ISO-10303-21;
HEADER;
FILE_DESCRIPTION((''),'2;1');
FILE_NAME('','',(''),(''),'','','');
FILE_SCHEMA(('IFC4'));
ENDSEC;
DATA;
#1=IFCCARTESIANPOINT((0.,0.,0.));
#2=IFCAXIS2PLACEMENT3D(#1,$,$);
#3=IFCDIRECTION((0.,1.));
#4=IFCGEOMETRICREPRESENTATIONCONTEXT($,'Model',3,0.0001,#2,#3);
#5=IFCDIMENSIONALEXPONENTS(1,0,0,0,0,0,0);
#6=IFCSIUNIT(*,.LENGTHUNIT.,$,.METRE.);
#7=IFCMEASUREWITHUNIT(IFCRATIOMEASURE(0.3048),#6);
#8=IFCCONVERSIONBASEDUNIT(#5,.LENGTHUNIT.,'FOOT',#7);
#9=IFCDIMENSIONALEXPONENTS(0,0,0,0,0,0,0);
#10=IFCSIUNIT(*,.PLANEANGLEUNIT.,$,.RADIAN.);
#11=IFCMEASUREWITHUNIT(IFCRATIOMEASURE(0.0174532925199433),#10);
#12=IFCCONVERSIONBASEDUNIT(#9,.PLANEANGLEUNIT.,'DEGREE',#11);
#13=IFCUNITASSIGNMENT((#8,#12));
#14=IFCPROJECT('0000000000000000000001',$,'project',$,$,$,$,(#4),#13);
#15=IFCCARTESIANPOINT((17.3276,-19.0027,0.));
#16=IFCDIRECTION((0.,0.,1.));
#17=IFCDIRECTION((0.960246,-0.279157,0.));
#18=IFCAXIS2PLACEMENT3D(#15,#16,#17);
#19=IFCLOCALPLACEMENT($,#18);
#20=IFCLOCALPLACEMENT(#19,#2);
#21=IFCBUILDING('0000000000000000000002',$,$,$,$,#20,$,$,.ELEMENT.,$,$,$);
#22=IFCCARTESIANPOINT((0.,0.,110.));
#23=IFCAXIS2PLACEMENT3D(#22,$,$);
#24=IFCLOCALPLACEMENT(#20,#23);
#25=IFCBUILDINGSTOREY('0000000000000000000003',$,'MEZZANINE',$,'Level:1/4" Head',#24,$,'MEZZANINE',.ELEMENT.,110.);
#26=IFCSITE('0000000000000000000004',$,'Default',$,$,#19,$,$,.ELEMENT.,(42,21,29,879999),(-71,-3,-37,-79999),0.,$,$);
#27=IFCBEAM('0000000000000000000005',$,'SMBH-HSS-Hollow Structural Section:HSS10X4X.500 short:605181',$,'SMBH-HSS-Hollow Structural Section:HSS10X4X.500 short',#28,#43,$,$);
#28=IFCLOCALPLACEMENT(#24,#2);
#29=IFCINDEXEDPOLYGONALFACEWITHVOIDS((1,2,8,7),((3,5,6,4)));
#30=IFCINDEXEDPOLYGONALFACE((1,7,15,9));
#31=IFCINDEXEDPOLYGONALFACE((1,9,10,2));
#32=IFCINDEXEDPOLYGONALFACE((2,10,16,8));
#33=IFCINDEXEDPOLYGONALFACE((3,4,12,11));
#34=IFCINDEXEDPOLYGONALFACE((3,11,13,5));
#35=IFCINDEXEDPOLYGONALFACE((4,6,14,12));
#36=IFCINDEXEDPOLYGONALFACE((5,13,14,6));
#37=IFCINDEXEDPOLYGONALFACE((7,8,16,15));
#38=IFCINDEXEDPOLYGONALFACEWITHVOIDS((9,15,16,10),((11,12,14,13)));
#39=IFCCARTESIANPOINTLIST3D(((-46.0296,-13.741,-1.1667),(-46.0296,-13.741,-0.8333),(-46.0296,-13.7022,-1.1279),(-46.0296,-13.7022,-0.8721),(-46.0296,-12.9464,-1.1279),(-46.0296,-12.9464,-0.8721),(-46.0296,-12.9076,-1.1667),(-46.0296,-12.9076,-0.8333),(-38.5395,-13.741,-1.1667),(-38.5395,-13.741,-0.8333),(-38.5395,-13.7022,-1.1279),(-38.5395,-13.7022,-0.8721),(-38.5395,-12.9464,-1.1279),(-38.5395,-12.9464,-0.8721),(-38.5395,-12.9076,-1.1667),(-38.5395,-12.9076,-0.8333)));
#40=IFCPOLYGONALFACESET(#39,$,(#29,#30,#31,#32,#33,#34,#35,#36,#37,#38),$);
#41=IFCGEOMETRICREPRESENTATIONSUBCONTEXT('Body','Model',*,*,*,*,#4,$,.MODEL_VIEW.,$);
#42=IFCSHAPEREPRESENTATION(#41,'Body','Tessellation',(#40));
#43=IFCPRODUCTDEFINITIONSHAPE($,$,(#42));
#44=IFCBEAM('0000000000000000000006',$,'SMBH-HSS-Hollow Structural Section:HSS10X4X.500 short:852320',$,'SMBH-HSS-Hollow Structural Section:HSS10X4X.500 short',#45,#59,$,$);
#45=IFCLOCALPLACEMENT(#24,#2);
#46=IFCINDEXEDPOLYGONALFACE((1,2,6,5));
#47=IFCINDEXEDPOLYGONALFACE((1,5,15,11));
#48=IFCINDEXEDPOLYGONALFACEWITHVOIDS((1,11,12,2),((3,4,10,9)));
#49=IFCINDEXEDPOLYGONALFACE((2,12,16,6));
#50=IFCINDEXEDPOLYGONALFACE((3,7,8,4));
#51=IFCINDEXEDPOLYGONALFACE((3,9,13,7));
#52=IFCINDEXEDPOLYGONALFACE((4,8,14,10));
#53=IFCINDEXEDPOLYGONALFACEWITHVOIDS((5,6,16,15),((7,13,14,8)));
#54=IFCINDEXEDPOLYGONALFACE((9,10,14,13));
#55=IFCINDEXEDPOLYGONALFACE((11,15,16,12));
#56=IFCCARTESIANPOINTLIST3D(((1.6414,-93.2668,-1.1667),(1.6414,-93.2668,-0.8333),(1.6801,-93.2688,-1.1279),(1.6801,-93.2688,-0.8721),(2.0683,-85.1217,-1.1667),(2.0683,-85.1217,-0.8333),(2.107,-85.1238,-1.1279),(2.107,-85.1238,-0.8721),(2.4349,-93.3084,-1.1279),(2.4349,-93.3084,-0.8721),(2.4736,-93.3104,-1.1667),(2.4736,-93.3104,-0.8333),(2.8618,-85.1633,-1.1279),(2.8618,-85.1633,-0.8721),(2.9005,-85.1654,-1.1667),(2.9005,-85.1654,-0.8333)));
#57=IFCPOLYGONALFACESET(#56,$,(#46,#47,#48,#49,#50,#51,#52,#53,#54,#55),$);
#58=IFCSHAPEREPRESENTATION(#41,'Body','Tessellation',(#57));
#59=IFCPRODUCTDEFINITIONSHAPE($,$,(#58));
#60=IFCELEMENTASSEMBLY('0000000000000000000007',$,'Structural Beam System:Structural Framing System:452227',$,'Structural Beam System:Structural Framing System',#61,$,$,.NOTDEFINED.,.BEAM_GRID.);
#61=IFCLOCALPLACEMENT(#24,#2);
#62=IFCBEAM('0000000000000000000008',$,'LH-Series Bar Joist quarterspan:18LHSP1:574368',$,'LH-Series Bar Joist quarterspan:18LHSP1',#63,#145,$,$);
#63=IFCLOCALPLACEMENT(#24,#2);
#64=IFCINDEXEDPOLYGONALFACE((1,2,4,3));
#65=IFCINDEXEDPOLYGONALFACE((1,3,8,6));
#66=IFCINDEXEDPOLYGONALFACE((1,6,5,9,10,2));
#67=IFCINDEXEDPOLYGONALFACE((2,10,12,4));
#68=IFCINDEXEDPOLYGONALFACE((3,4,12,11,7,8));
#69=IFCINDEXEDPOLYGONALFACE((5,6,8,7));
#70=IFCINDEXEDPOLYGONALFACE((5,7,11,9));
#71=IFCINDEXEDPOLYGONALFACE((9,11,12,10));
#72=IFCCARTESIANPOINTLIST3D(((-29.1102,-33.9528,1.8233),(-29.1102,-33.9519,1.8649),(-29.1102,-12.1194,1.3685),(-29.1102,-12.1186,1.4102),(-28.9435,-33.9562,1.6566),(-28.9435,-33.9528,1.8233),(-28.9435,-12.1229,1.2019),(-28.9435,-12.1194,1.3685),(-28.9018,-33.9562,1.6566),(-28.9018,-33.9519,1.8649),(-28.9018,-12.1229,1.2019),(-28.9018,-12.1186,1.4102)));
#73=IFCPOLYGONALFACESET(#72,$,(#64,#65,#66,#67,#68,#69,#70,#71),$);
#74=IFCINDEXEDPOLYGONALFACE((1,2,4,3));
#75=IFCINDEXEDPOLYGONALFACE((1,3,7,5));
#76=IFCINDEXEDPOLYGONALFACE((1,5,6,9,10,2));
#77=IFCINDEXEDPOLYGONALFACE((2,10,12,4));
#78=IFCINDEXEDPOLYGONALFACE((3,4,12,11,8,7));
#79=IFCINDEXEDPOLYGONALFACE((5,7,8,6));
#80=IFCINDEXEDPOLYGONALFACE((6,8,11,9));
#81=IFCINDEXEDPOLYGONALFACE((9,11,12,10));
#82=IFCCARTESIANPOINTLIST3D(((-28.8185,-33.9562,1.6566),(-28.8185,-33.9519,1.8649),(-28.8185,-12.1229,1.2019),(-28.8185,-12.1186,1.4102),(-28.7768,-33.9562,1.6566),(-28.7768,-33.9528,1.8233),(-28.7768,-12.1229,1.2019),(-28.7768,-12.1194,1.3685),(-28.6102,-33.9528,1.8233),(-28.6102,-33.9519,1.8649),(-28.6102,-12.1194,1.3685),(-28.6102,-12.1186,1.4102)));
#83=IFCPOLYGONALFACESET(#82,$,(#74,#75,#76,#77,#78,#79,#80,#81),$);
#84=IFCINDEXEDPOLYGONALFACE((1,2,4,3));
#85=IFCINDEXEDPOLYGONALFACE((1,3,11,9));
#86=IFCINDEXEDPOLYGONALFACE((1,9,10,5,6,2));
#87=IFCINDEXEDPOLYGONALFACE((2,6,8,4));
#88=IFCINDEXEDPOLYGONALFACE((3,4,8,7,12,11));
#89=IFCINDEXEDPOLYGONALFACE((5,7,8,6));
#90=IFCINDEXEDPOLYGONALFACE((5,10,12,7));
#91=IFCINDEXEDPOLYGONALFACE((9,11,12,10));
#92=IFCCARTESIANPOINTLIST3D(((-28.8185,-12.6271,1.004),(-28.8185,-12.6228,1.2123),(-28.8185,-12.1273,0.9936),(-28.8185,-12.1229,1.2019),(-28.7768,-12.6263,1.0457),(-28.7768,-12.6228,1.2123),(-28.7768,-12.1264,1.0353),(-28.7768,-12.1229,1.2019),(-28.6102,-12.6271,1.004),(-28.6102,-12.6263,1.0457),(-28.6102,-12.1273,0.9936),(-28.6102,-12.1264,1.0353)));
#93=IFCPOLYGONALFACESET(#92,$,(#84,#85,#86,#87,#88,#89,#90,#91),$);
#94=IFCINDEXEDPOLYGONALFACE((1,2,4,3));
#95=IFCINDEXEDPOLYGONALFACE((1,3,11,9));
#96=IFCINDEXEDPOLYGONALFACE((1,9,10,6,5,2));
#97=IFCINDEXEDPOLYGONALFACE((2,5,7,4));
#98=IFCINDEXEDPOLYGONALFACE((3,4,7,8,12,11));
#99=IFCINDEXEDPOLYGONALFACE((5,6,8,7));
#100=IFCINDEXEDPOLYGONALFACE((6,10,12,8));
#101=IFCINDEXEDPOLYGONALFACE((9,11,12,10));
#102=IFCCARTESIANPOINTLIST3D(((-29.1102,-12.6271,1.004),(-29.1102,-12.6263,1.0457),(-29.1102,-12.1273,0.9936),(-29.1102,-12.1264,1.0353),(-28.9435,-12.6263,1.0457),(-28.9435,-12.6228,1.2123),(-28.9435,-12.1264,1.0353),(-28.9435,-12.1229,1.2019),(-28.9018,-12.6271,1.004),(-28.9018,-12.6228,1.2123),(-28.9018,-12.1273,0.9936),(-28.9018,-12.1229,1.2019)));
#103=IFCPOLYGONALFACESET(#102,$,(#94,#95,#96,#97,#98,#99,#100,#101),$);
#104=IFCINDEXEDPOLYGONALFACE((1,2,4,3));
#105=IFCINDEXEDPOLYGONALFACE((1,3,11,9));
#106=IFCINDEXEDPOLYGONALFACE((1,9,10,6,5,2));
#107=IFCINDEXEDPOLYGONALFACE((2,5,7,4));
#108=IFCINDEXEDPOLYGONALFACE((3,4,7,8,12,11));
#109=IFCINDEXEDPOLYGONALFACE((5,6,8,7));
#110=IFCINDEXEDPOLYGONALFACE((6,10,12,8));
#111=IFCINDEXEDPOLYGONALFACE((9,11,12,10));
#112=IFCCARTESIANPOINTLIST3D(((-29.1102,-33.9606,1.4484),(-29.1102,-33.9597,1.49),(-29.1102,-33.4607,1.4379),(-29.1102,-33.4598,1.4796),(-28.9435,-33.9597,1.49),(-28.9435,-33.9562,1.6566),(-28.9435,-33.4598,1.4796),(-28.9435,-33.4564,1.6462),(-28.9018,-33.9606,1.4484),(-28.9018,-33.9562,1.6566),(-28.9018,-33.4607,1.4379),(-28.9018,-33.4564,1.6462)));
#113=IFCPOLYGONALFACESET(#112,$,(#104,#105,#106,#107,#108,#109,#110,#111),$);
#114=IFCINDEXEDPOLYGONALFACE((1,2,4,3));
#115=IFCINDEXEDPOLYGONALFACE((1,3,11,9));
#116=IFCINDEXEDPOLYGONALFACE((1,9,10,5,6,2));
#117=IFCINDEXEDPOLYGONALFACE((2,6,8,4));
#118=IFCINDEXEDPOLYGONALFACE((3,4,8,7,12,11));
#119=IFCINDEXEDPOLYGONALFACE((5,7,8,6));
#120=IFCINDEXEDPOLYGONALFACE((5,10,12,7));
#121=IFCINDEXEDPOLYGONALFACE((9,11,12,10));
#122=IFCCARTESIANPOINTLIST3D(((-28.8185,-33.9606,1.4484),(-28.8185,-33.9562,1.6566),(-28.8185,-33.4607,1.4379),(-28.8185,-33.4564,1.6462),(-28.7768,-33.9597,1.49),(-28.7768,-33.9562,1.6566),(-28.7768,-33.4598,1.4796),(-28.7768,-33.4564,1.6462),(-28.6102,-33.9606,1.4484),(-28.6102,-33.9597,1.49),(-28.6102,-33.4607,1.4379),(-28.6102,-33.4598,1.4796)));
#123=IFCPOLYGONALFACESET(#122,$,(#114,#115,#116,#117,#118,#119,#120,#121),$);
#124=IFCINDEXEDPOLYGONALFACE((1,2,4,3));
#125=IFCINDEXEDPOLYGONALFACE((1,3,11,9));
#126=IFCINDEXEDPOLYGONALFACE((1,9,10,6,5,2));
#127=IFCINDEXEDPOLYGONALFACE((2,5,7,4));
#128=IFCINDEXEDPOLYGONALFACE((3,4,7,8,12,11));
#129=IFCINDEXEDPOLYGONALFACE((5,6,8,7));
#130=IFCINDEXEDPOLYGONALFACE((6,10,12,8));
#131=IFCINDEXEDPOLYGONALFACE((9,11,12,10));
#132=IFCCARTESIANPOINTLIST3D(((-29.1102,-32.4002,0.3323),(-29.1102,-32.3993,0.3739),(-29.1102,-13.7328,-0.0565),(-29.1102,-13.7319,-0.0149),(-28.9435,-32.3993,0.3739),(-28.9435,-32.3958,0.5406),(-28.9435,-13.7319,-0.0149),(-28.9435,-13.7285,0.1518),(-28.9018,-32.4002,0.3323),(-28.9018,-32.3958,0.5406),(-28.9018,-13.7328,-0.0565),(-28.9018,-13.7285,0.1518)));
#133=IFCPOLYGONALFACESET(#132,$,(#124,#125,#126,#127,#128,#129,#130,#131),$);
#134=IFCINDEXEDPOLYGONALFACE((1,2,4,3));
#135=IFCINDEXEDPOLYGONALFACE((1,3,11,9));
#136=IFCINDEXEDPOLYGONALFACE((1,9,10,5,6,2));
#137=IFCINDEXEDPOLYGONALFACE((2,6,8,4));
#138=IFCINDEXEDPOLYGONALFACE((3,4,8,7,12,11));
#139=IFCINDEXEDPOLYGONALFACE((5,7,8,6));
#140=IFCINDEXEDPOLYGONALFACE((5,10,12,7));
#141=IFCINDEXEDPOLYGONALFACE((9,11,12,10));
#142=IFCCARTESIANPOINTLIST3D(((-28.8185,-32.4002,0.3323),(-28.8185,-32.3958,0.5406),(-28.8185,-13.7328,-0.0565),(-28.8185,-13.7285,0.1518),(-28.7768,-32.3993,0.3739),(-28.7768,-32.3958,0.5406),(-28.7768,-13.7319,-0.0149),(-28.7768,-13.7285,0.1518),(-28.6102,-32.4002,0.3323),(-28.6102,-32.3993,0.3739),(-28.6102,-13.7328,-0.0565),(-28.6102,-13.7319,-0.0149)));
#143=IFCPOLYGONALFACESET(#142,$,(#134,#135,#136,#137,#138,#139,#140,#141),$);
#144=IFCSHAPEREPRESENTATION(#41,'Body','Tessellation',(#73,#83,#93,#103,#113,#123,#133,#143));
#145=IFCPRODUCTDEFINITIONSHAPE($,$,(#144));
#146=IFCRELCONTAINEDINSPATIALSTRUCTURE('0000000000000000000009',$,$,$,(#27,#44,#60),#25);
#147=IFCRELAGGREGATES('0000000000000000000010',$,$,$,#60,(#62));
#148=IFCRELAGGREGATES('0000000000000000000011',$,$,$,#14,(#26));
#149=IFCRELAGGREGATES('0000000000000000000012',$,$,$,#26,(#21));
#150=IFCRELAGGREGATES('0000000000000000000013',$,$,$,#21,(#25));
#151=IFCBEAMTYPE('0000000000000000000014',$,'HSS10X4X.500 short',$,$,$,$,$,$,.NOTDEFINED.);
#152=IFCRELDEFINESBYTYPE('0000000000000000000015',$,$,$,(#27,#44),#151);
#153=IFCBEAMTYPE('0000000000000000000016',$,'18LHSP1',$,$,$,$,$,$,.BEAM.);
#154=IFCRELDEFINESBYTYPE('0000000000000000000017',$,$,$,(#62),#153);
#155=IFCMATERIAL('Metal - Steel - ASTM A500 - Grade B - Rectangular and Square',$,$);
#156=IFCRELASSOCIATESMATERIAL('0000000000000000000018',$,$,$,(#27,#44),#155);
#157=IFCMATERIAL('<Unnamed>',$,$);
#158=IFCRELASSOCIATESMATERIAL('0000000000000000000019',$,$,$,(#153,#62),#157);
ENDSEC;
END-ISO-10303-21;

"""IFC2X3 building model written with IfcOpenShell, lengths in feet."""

from ifc_helpers import new_model, entity, si_unit, converted_unit, direction, frame, frame_2d, origin, place, context, subcontext, project, spatial, polyline, rectangle, outline, extrude, boolean, source, transform, mapped, material, type_object, type_shapes, element, aggregate, save


model = new_model("IFC2X3")

# Units and contexts
model_context = context("Model", 3, precision=0.0001, world=origin(), true_north=direction((0.0, 1.0)))
body_context = subcontext(model_context, "Body", "Model", "MODEL_VIEW")
ifc_project = project(units=[converted_unit("LENGTHUNIT", "FOOT", entity("IfcRatioMeasure", 0.3048), si_unit("LENGTHUNIT", "METRE"), dimensions=[1, 0, 0, 0, 0, 0, 0]), converted_unit("PLANEANGLEUNIT", "DEGREE", entity("IfcRatioMeasure", 0.0174532925199433), si_unit("PLANEANGLEUNIT", "RADIAN"), dimensions=[0, 0, 0, 0, 0, 0, 0])], contexts=[model_context])

# Site, building, storey
site_placement = place(None, frame((17.3276, -19.0027, 0.0), z_axis=(0.0, 0.0, 1.0), x_axis=(0.960246, -0.279157, 0.0)))
site = spatial("IfcSite", under=ifc_project, at=site_placement, Name="Default", CompositionType="ELEMENT", RefLatitude=(42, 21, 29, 879999), RefLongitude=(-71, -3, -37, -79999), RefElevation=0.0)
building_placement = place(site_placement, origin())
building = spatial("IfcBuilding", under=site, at=building_placement, CompositionType="ELEMENT")
storey_placement = place(building_placement, frame((0.0, 0.0, 110.0)))
storey = spatial("IfcBuildingStorey", under=building, at=storey_placement, Name="MEZZANINE", ObjectType="Level:1/4\" Head", LongName="MEZZANINE", CompositionType="ELEMENT", Elevation=110.0)

# Shared definitions
ifc_material_1 = material(Name="Metal - Steel - ASTM A500 - Grade B - Rectangular and Square")

# Beams
beam_type_1 = type_object("IfcBeamType", Name="HSS10X4X.500 short", PredefinedType="NOTDEFINED")
beam_1_placement = place(storey_placement, frame((-46.2379, -13.3243, -0.8333)))
element("IfcBeam", 1, at=beam_1_placement, inside=storey, type_object=beam_type_1, material=ifc_material_1, Name="SMBH-HSS-Hollow Structural Section:HSS10X4X.500 short:605181", ObjectType="SMBH-HSS-Hollow Structural Section:HSS10X4X.500 short", context=body_context, shape_type="SweptSolid", body=[
    boolean("DIFFERENCE", extrude(rectangle(XDim=0.3333, YDim=0.8333, at=frame_2d((0.0, 0.0), x_axis=(1.0, 0.0))), frame((0.2083, 0.0, -0.1667), z_axis=(1.0, 0.0, 0.0), x_axis=(0.0, 0.0, -1.0)), (0.0, 0.0, 1.0), 7.4901), extrude(rectangle(XDim=0.2559, YDim=0.7559, at=frame_2d((0.0, 0.0), x_axis=(0.0, 1.0))), frame((7.6985, 0.0, -0.1667), z_axis=(-1.0, 0.0, 0.0), x_axis=(0.0, 1.0, 0.0)), (0.0, 0.0, 1.0), 7.4901)),
])
beam_2_placement = place(storey_placement, frame((2.0575, -93.2886, -0.8333), z_axis=(0.0, 0.0, 1.0), x_axis=(0.052336, 0.99863, 0.0)))
element("IfcBeam", 2, at=beam_2_placement, inside=storey, type_object=beam_type_1, material=ifc_material_1, Name="SMBH-HSS-Hollow Structural Section:HSS10X4X.500 short:852320", ObjectType="SMBH-HSS-Hollow Structural Section:HSS10X4X.500 short", context=body_context, shape_type="SweptSolid", body=[
    boolean("DIFFERENCE", extrude(rectangle(XDim=0.3333, YDim=0.8333, at=frame_2d((0.0, 0.0), x_axis=(1.0, 0.0))), frame((0.0, 0.0, -0.1667), z_axis=(1.0, 0.0, 0.0), x_axis=(0.0, 0.0, -1.0)), (0.0, 0.0, 1.0), 8.1562), extrude(rectangle(XDim=0.2559, YDim=0.7559, at=frame_2d((0.0, 0.0), x_axis=(0.0, 1.0))), frame((8.1562, 0.0, -0.1667), z_axis=(-1.0, 0.0, 0.0), x_axis=(0.0, 1.0, 0.0)), (0.0, 0.0, 1.0), 8.1562)),
])

# Element assembly, beam
assembly_1_placement = place(storey_placement, origin())
assembly_1 = element("IfcElementAssembly", 3, at=assembly_1_placement, inside=storey, Name="Structural Beam System:Structural Framing System:452227", ObjectType="Structural Beam System:Structural Framing System", AssemblyPlace="NOTDEFINED", PredefinedType="BEAM_GRID")
ifc_material_2 = material(Name="<Unnamed>")
beam_type_2 = type_object("IfcBeamType", Name="18LHSP1", PredefinedType="BEAM", material=ifc_material_2)
shared_shape_1 = source(origin(), body_context, "Body", "SweptSolid", [
    extrude(outline(polyline([(-0.0833, -0.125), (-0.0417, -0.125), (-0.0417, 0.0417), (0.125, 0.0417), (0.125, 0.0833), (-0.0833, 0.0833), (-0.0833, -0.125)])), frame((-10.919, -0.125, 0.6667), z_axis=(1.0, 0.0, 0.0), x_axis=(0.0, 0.0, -1.0)), (0.0, 0.0, 1.0), 21.8381),
    extrude(outline(polyline([(-0.0833, -0.0833), (0.125, -0.0833), (0.125, -0.0417), (-0.0417, -0.0417), (-0.0417, 0.125), (-0.0833, 0.125), (-0.0833, -0.0833)])), frame((-10.919, 0.125, 0.6667), z_axis=(1.0, 0.0, 0.0), x_axis=(0.0, 0.0, -1.0)), (0.0, 0.0, 1.0), 21.8381),
    extrude(outline(polyline([(-0.125, -0.0833), (0.0833, -0.0833), (0.0833, 0.125), (0.0417, 0.125), (0.0417, -0.0417), (-0.125, -0.0417), (-0.125, -0.0833)])), frame((-10.919, 0.125, 0.4167), z_axis=(1.0, 0.0, 0.0), x_axis=(0.0, 0.0, -1.0)), (0.0, 0.0, 1.0), 0.5),
    extrude(outline(polyline([(0.0417, -0.125), (0.0833, -0.125), (0.0833, 0.0833), (-0.125, 0.0833), (-0.125, 0.0417), (0.0417, 0.0417), (0.0417, -0.125)])), frame((-10.919, -0.125, 0.4167), z_axis=(1.0, 0.0, 0.0), x_axis=(0.0, 0.0, -1.0)), (0.0, 0.0, 1.0), 0.5),
    extrude(outline(polyline([(0.0417, -0.125), (0.0833, -0.125), (0.0833, 0.0833), (-0.125, 0.0833), (-0.125, 0.0417), (0.0417, 0.0417), (0.0417, -0.125)])), frame((10.419, -0.125, 0.4167), z_axis=(1.0, 0.0, 0.0), x_axis=(0.0, 0.0, -1.0)), (0.0, 0.0, 1.0), 0.5),
    extrude(outline(polyline([(-0.125, -0.0833), (0.0833, -0.0833), (0.0833, 0.125), (0.0417, 0.125), (0.0417, -0.0417), (-0.125, -0.0417), (-0.125, -0.0833)])), frame((10.419, 0.125, 0.4167), z_axis=(1.0, 0.0, 0.0), x_axis=(0.0, 0.0, -1.0)), (0.0, 0.0, 1.0), 0.5),
    extrude(outline(polyline([(0.0417, -0.125), (0.0833, -0.125), (0.0833, 0.0833), (-0.125, 0.0833), (-0.125, 0.0417), (0.0417, 0.0417), (0.0417, -0.125)])), frame((-9.3357, -0.125, -0.6667), z_axis=(1.0, 0.0, 0.0), x_axis=(0.0, 0.0, -1.0)), (0.0, 0.0, 1.0), 18.6714),
    extrude(outline(polyline([(-0.125, -0.0833), (0.0833, -0.0833), (0.0833, 0.125), (0.0417, 0.125), (0.0417, -0.0417), (-0.125, -0.0417), (-0.125, -0.0833)])), frame((-9.3357, 0.125, -0.6667), z_axis=(1.0, 0.0, 0.0), x_axis=(0.0, 0.0, -1.0)), (0.0, 0.0, 1.0), 18.6714),
])
type_shapes(beam_type_2, [shared_shape_1])
beam_3_placement = place(assembly_1_placement, frame((-28.8602, -23.0509, 0.8877), z_axis=(0.0, 0.020824, 0.999783), x_axis=(0.0, -0.999783, 0.020824)))
beam_3 = element("IfcBeam", 4, at=beam_3_placement, type_object=beam_type_2, material=ifc_material_2, Name="LH-Series Bar Joist quarterspan:18LHSP1:574368", ObjectType="LH-Series Bar Joist quarterspan:18LHSP1", context=body_context, shape_type="MappedRepresentation", body=[
    mapped(shared_shape_1, transform((0.0, 0.0, 0.0), scale=1.0)),
])
aggregate(assembly_1, [beam_3])

save(model, "model.ifc")
